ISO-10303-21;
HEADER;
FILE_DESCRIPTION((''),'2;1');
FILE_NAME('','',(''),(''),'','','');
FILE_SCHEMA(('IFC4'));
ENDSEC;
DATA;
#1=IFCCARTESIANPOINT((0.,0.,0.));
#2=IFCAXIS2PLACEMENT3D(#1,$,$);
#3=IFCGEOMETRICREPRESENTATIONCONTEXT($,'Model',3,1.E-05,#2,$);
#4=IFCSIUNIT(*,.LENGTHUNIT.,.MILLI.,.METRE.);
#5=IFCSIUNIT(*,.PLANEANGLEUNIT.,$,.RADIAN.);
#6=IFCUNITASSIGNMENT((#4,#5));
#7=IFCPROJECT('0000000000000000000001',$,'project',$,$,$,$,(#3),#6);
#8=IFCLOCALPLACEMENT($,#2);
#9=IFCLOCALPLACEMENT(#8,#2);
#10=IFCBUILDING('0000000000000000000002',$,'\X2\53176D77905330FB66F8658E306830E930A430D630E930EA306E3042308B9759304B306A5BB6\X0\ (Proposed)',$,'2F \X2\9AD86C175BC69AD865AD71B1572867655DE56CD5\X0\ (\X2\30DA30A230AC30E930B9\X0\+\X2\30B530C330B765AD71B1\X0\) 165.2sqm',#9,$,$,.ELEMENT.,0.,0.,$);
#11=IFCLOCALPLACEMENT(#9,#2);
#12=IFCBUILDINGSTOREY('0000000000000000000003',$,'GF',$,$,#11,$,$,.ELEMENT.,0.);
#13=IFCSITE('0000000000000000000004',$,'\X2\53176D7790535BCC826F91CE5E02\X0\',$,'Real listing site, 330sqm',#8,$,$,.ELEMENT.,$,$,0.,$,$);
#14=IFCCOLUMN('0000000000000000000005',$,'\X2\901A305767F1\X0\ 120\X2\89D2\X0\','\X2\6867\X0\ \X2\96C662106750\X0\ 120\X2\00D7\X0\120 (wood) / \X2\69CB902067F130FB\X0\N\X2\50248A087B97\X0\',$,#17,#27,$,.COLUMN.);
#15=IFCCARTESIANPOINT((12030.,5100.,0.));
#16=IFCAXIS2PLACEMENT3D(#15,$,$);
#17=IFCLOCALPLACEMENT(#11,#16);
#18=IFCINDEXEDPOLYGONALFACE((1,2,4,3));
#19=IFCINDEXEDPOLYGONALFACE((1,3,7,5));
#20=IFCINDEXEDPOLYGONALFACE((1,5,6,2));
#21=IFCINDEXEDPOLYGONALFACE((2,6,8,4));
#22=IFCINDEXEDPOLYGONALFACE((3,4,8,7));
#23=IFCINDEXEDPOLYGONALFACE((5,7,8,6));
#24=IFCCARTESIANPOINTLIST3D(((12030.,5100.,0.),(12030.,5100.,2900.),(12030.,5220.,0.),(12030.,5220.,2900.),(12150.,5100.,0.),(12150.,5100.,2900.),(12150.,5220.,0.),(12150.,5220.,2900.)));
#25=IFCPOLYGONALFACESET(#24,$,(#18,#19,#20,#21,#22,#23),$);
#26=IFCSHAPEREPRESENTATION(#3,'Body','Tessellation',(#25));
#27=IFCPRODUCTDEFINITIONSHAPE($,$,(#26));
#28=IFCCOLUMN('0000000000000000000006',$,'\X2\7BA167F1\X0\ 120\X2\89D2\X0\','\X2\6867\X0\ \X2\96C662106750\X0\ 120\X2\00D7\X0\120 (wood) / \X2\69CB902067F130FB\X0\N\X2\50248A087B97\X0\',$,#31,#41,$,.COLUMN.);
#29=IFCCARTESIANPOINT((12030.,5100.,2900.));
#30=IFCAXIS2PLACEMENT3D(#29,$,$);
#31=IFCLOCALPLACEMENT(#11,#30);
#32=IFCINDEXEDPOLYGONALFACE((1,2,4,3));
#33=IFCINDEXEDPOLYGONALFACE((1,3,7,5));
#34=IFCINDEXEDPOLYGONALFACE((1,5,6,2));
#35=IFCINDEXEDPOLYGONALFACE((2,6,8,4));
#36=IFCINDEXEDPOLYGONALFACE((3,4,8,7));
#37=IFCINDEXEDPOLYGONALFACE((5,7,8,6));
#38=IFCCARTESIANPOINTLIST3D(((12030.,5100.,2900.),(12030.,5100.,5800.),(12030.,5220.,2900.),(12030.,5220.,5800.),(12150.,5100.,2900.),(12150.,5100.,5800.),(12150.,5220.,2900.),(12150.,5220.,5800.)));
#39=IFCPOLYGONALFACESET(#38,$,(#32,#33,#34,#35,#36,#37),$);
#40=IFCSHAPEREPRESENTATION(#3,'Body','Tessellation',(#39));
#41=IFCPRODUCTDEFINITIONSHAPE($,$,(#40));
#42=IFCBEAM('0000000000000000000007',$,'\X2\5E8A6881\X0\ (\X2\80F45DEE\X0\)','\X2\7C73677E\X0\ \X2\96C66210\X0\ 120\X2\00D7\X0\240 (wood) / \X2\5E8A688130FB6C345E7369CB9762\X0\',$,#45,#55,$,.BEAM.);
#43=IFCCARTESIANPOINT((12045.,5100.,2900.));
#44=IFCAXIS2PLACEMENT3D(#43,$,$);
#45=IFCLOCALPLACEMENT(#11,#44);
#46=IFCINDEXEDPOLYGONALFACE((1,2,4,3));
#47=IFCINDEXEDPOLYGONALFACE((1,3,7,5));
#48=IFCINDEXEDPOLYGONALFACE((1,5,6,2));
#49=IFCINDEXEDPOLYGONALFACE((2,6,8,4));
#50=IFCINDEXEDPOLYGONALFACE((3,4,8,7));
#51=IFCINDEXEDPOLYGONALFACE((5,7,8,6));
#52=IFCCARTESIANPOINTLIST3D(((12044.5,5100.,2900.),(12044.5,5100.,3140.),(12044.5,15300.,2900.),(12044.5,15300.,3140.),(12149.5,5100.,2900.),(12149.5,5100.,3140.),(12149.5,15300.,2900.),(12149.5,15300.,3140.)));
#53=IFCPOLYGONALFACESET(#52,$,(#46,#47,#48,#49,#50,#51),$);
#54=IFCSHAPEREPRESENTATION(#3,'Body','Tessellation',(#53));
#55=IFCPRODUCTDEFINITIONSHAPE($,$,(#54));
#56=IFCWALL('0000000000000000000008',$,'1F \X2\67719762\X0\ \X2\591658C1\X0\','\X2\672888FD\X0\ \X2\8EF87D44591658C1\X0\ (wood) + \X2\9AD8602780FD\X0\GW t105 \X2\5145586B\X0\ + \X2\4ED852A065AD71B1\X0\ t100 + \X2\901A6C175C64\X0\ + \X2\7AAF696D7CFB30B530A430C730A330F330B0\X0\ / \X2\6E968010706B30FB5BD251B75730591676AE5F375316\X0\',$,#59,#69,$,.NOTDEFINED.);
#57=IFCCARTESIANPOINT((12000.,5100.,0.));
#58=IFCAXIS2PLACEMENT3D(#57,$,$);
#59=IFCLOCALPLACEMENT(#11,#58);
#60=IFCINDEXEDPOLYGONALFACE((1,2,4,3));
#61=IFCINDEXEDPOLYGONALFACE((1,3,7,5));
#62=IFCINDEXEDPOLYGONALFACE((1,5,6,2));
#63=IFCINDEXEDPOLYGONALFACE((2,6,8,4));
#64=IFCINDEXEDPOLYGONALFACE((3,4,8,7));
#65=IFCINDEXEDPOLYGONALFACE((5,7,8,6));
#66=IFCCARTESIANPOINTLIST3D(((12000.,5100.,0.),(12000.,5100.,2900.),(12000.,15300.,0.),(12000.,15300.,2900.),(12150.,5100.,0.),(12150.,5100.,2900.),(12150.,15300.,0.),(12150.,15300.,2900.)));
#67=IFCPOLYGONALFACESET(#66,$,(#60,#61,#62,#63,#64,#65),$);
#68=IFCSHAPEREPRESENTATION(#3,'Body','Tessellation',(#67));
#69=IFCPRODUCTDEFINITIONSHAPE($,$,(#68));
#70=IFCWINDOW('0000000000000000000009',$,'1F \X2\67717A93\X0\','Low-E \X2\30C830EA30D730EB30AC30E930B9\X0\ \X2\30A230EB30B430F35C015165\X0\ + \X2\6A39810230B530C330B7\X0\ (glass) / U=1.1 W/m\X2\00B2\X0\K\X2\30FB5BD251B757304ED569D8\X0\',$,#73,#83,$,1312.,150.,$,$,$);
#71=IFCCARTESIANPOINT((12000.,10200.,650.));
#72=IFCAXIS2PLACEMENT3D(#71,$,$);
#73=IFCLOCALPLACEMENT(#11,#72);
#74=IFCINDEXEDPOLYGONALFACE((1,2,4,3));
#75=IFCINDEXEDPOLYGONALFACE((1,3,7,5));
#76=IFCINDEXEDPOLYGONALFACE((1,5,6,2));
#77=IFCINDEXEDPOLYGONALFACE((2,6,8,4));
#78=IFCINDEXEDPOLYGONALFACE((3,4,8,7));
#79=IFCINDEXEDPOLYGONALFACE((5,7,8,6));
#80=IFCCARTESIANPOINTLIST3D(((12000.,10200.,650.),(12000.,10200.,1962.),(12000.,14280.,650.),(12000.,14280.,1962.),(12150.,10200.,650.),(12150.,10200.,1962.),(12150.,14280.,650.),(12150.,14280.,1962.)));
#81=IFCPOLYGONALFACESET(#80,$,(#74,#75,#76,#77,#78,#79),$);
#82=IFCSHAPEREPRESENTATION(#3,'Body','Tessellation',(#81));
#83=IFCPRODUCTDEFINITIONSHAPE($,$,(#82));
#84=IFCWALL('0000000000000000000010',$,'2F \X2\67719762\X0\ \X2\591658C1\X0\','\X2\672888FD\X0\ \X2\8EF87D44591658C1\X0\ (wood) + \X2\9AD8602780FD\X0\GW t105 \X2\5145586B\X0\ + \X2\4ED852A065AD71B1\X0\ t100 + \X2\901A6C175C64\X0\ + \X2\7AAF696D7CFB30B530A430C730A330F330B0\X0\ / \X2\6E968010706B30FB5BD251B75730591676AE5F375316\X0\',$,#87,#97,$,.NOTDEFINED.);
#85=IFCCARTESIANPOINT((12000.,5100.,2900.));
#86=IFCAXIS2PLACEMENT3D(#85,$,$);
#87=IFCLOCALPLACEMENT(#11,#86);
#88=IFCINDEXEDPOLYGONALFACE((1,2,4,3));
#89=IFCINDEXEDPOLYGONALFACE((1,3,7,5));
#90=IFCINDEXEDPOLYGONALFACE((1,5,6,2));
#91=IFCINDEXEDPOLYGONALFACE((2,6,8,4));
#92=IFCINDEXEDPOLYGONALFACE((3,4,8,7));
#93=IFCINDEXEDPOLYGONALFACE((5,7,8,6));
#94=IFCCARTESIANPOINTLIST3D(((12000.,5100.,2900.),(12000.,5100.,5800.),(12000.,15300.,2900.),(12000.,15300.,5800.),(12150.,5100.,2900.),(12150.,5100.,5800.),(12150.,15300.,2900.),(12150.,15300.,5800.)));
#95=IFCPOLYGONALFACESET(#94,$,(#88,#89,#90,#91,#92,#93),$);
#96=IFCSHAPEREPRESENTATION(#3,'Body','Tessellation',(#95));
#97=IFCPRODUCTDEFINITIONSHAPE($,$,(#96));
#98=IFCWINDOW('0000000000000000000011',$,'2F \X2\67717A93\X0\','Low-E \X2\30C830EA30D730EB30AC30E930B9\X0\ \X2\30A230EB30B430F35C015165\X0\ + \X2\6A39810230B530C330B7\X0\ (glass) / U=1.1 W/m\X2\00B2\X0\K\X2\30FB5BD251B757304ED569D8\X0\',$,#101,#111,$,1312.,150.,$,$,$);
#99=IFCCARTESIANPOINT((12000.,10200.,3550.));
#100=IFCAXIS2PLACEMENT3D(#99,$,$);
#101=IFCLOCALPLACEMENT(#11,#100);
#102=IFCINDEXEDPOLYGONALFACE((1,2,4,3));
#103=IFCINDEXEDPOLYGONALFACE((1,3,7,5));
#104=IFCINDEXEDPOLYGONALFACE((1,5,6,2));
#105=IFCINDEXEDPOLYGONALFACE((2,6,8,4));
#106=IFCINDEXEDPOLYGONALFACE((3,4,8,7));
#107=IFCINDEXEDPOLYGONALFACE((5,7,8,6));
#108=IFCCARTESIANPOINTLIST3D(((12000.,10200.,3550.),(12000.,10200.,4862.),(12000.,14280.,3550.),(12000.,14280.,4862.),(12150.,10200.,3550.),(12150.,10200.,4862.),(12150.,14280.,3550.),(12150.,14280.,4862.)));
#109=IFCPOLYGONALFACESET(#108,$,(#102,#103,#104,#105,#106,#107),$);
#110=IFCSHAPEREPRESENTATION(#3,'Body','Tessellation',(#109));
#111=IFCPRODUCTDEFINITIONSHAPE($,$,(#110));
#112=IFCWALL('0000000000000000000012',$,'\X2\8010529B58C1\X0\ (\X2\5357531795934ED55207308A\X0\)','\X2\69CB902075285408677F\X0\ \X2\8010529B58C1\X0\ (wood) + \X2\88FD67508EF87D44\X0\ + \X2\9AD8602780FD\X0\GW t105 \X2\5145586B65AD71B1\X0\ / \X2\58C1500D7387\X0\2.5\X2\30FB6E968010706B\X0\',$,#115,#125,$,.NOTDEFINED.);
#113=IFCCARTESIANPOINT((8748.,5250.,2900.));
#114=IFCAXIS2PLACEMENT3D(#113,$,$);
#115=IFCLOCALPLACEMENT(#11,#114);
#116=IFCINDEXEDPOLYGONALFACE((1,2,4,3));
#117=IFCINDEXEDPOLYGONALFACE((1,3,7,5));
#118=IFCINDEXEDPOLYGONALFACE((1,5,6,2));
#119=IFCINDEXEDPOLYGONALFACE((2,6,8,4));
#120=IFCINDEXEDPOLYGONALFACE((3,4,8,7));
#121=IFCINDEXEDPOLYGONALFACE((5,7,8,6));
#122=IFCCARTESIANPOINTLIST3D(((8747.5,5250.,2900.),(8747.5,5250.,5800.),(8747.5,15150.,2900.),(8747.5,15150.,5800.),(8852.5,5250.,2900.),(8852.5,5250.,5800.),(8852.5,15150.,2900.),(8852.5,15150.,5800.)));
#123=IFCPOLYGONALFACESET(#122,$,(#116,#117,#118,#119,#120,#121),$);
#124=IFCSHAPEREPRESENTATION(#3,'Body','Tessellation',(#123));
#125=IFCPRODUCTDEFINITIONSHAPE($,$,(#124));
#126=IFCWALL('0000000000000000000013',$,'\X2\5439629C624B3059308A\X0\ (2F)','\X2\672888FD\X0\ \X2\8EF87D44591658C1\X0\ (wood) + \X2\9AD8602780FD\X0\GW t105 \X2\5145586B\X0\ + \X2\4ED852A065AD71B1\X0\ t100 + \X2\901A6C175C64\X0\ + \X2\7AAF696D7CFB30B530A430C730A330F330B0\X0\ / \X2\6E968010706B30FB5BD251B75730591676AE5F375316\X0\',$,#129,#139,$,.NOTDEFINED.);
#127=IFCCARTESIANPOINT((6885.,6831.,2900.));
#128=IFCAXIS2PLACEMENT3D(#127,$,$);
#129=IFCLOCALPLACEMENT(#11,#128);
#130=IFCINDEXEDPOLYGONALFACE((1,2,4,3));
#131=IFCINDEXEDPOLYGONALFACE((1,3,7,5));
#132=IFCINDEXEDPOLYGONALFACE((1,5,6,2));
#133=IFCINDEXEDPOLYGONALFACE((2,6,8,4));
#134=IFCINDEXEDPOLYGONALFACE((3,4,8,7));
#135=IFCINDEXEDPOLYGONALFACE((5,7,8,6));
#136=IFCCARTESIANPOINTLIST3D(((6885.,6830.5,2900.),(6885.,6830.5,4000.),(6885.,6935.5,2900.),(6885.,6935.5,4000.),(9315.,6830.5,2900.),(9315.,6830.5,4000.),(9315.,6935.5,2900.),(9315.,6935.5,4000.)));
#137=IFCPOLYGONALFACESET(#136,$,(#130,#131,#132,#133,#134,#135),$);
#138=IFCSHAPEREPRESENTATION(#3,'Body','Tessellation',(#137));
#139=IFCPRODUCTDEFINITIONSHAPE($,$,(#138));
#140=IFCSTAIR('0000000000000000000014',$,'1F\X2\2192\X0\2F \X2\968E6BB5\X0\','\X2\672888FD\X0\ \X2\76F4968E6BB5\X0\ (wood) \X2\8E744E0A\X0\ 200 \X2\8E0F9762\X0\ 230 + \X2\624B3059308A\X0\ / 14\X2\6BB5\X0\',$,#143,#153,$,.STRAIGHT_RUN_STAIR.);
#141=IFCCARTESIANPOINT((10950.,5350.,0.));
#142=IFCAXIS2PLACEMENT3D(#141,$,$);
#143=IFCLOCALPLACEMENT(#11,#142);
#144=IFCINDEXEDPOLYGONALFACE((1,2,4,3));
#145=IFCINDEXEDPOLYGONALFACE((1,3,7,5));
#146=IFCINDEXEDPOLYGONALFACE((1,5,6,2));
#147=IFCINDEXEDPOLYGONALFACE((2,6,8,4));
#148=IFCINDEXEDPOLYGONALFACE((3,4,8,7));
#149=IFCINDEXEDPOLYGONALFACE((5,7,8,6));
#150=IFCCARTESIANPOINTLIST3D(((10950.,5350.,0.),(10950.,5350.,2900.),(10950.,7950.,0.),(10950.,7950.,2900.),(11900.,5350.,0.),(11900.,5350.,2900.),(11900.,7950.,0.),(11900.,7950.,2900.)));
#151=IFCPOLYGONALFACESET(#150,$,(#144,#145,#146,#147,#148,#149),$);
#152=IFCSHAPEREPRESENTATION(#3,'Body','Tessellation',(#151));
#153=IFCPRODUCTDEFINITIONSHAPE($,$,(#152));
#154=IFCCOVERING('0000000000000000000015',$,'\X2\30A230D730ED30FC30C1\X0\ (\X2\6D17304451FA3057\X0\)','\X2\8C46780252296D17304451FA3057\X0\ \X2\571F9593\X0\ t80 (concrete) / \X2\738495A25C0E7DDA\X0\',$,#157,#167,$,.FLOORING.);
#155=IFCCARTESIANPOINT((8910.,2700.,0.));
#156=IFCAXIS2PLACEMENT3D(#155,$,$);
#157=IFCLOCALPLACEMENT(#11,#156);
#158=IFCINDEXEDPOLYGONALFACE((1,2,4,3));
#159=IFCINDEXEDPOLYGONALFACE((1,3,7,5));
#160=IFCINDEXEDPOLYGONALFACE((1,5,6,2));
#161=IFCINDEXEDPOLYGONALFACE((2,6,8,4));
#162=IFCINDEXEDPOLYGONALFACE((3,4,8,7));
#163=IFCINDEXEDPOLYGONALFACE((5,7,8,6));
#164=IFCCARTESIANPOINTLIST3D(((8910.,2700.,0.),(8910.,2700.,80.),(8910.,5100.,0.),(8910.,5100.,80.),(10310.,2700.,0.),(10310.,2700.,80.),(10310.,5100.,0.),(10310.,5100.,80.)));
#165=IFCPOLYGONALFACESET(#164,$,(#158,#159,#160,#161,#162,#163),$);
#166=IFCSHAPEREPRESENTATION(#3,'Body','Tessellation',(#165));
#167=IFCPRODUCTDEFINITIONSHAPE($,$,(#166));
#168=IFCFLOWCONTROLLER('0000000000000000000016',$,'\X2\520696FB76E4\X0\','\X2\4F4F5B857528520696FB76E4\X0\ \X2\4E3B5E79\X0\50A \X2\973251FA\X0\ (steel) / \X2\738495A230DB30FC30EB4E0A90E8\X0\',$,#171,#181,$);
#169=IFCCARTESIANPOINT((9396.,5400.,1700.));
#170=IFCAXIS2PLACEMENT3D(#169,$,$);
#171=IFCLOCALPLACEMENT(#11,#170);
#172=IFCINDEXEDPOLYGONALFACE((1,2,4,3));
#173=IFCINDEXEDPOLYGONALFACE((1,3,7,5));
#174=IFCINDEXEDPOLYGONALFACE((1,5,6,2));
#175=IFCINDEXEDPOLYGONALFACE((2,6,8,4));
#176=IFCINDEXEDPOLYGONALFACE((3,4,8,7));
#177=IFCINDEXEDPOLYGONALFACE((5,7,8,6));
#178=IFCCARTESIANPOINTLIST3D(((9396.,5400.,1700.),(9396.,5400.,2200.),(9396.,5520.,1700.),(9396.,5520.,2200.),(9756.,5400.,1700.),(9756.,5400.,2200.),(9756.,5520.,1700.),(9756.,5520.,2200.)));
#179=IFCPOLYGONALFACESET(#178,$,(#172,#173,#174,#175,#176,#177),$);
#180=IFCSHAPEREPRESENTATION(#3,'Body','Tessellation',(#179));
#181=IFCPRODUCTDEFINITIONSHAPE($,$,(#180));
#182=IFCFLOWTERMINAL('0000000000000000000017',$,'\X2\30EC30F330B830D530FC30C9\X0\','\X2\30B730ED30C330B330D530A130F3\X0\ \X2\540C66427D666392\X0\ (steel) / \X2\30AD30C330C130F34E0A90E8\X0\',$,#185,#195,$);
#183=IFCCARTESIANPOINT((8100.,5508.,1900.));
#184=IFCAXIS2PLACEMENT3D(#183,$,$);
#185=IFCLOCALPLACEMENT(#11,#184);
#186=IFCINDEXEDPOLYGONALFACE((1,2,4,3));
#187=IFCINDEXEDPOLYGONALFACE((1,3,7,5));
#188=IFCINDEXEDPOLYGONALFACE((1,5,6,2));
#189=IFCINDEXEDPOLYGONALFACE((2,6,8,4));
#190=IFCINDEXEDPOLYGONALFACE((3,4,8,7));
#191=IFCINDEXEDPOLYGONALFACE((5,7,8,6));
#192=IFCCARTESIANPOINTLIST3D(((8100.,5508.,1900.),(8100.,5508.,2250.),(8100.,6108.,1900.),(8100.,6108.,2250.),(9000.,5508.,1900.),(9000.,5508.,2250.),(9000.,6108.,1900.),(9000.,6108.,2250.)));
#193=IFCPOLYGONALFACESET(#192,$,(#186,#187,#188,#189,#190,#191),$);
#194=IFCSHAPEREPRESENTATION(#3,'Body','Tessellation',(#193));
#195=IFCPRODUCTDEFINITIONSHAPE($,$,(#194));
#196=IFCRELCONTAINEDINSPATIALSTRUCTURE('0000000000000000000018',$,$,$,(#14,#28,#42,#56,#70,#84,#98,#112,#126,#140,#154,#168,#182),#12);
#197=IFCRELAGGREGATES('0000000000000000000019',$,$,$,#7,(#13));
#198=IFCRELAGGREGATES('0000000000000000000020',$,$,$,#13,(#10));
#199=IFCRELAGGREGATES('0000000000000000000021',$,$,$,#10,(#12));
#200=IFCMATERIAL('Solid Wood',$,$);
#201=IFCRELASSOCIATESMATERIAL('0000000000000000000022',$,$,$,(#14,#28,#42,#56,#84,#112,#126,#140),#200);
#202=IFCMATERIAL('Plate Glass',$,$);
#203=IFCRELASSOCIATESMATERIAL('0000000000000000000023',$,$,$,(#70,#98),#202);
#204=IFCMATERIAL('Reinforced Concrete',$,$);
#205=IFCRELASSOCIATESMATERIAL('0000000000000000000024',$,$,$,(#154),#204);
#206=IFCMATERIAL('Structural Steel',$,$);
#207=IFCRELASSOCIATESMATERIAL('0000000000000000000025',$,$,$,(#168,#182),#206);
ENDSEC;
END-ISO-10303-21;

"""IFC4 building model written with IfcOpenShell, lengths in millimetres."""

from ifc_helpers import new_model, si_unit, frame, frame_2d, origin, place, context, project, spatial, rectangle, extrude, material, element, fill, save


model = new_model("IFC4")

# Units and contexts
model_context = context("Model", 3, precision=1e-05, world=origin())
ifc_project = project(units=[si_unit("LENGTHUNIT", "METRE", prefix="MILLI"), si_unit("PLANEANGLEUNIT", "RADIAN")], contexts=[model_context])

# Site, building, storey
site_placement = place(None, origin())
site = spatial("IfcSite", under=ifc_project, at=site_placement, Name="北海道富良野市", ObjectType="Real listing site, 330sqm", CompositionType="ELEMENT", RefElevation=0.0)
building_placement = place(site_placement, origin())
building = spatial("IfcBuilding", under=site, at=building_placement, Name="北海道・書斎とライブラリのある静かな家 (Proposed)", ObjectType="2F 高気密高断熱在来工法 (ペアガラス+サッシ断熱) 165.2sqm", CompositionType="ELEMENT", ElevationOfRefHeight=0.0, ElevationOfTerrain=0.0)
storey_placement = place(building_placement, origin())
storey = spatial("IfcBuildingStorey", under=building, at=storey_placement, Name="GF", CompositionType="ELEMENT", Elevation=0.0)

# Columns
ifc_material_1 = material(Name="Solid Wood")
column_1_placement = place(storey_placement, frame((12030.0, 5100.0, 0.0)))
element("IfcColumn", 1, at=column_1_placement, inside=storey, material=ifc_material_1, Name="通し柱 120角", Description="桧 集成材 120×120 (wood) / 構造柱・N値計算", PredefinedType="COLUMN", context=model_context, shape_type="SweptSolid", body=[
    extrude(rectangle(XDim=120.0, YDim=120.0, at=frame_2d((60.0, 60.0))), frame((12030.0, 5100.0, 0.0)), (0.0, 0.0, 1.0), 2900.0),
])
column_2_placement = place(storey_placement, frame((12030.0, 5100.0, 2900.0)))
element("IfcColumn", 2, at=column_2_placement, inside=storey, material=ifc_material_1, Name="管柱 120角", Description="桧 集成材 120×120 (wood) / 構造柱・N値計算", PredefinedType="COLUMN", context=model_context, shape_type="SweptSolid", body=[
    extrude(rectangle(XDim=120.0, YDim=120.0, at=frame_2d((60.0, 60.0))), frame((12030.0, 5100.0, 2900.0)), (0.0, 0.0, 1.0), 2900.0),
])

# Beam
beam_1_placement = place(storey_placement, frame((12045.0, 5100.0, 2900.0)))
element("IfcBeam", 3, at=beam_1_placement, inside=storey, material=ifc_material_1, Name="床梁 (胴差)", Description="米松 集成 120×240 (wood) / 床梁・水平構面", PredefinedType="BEAM", context=model_context, shape_type="SweptSolid", body=[
    extrude(rectangle(XDim=105.0, YDim=10200.0, at=frame_2d((52.0, 5100.0))), frame((12045.0, 5100.0, 2900.0)), (0.0, 0.0, 1.0), 240.0),
])

# Wall, opening, window
wall_1_placement = place(storey_placement, frame((12000.0, 5100.0, 0.0)))
wall_1 = element("IfcWall", 4, at=wall_1_placement, inside=storey, material=ifc_material_1, Name="1F 東面 外壁", Description="木製 軸組外壁 (wood) + 高性能GW t105 充填 + 付加断熱 t100 + 通気層 + 窯業系サイディング / 準耐火・寒冷地外皮強化", PredefinedType="NOTDEFINED", context=model_context, shape_type="SweptSolid", body=[
    extrude(rectangle(XDim=150.0, YDim=10200.0, at=frame_2d((75.0, 5100.0))), frame((12000.0, 5100.0, 0.0)), (0.0, 0.0, 1.0), 2900.0),
])
opening_1_placement = place(storey_placement, frame((12000.0, 10200.0, 650.0)))
opening_1 = element("IfcOpeningElement", 5, at=opening_1_placement, cuts=wall_1, PredefinedType="NOTDEFINED", context=model_context, shape_type="SweptSolid", body=[
    extrude(rectangle(XDim=150.0, YDim=4080.0, at=frame_2d((75.0, 2040.0))), frame((12000.0, 10200.0, 650.0)), (0.0, 0.0, 1.0), 1312.0),
])
ifc_material_2 = material(Name="Plate Glass")
window_1_placement = place(storey_placement, frame((12000.0, 10200.0, 650.0)))
window_1 = element("IfcWindow", 6, at=window_1_placement, inside=storey, material=ifc_material_2, Name="1F 東窓", Description="Low-E トリプルガラス アルゴン封入 + 樹脂サッシ (glass) / U=1.1 W/m²K・寒冷地仕様", OverallHeight=1312.0, OverallWidth=150.0, context=model_context, shape_type="SweptSolid", body=[
    extrude(rectangle(XDim=150.0, YDim=4080.0, at=frame_2d((75.0, 2040.0))), frame((12000.0, 10200.0, 650.0)), (0.0, 0.0, 1.0), 1312.0),
])
fill(opening_1, window_1)

# Wall, opening, window
wall_2_placement = place(storey_placement, frame((12000.0, 5100.0, 2900.0)))
wall_2 = element("IfcWall", 7, at=wall_2_placement, inside=storey, material=ifc_material_1, Name="2F 東面 外壁", Description="木製 軸組外壁 (wood) + 高性能GW t105 充填 + 付加断熱 t100 + 通気層 + 窯業系サイディング / 準耐火・寒冷地外皮強化", PredefinedType="NOTDEFINED", context=model_context, shape_type="SweptSolid", body=[
    extrude(rectangle(XDim=150.0, YDim=10200.0, at=frame_2d((75.0, 5100.0))), frame((12000.0, 5100.0, 2900.0)), (0.0, 0.0, 1.0), 2900.0),
])
opening_2_placement = place(storey_placement, frame((12000.0, 10200.0, 3550.0)))
opening_2 = element("IfcOpeningElement", 8, at=opening_2_placement, cuts=wall_2, PredefinedType="NOTDEFINED", context=model_context, shape_type="SweptSolid", body=[
    extrude(rectangle(XDim=150.0, YDim=4080.0, at=frame_2d((75.0, 2040.0))), frame((12000.0, 10200.0, 3550.0)), (0.0, 0.0, 1.0), 1312.0),
])
window_2_placement = place(storey_placement, frame((12000.0, 10200.0, 3550.0)))
window_2 = element("IfcWindow", 9, at=window_2_placement, inside=storey, material=ifc_material_2, Name="2F 東窓", Description="Low-E トリプルガラス アルゴン封入 + 樹脂サッシ (glass) / U=1.1 W/m²K・寒冷地仕様", OverallHeight=1312.0, OverallWidth=150.0, context=model_context, shape_type="SweptSolid", body=[
    extrude(rectangle(XDim=150.0, YDim=4080.0, at=frame_2d((75.0, 2040.0))), frame((12000.0, 10200.0, 3550.0)), (0.0, 0.0, 1.0), 1312.0),
])
fill(opening_2, window_2)

# Walls
wall_3_placement = place(storey_placement, frame((8748.0, 5250.0, 2900.0)))
element("IfcWall", 10, at=wall_3_placement, inside=storey, material=ifc_material_1, Name="耐力壁 (南北間仕切り)", Description="構造用合板 耐力壁 (wood) + 製材軸組 + 高性能GW t105 充填断熱 / 壁倍率2.5・準耐火", PredefinedType="NOTDEFINED", context=model_context, shape_type="SweptSolid", body=[
    extrude(rectangle(XDim=105.0, YDim=9900.0, at=frame_2d((52.0, 4950.0))), frame((8748.0, 5250.0, 2900.0)), (0.0, 0.0, 1.0), 2900.0),
])
wall_4_placement = place(storey_placement, frame((6885.0, 6831.0, 2900.0)))
element("IfcWall", 11, at=wall_4_placement, inside=storey, material=ifc_material_1, Name="吹抜手すり (2F)", Description="木製 軸組外壁 (wood) + 高性能GW t105 充填 + 付加断熱 t100 + 通気層 + 窯業系サイディング / 準耐火・寒冷地外皮強化", PredefinedType="NOTDEFINED", context=model_context, shape_type="SweptSolid", body=[
    extrude(rectangle(XDim=2430.0, YDim=105.0, at=frame_2d((1215.0, 52.0))), frame((6885.0, 6831.0, 2900.0)), (0.0, 0.0, 1.0), 1100.0),
])

# Stair
stair_placement = place(storey_placement, frame((10950.0, 5350.0, 0.0)))
element("IfcStair", 12, at=stair_placement, inside=storey, material=ifc_material_1, Name="1F→2F 階段", Description="木製 直階段 (wood) 蹴上 200 踏面 230 + 手すり / 14段", PredefinedType="STRAIGHT_RUN_STAIR", context=model_context, shape_type="SweptSolid", body=[
    extrude(rectangle(XDim=950.0, YDim=2600.0, at=frame_2d((475.0, 1300.0))), frame((10950.0, 5350.0, 0.0)), (0.0, 0.0, 1.0), 2900.0),
])

# Covering
ifc_material_3 = material(Name="Reinforced Concrete")
covering_placement = place(storey_placement, frame((8910.0, 2700.0, 0.0)))
element("IfcCovering", 13, at=covering_placement, inside=storey, material=ifc_material_3, Name="アプローチ (洗い出し)", Description="豆砂利洗い出し 土間 t80 (concrete) / 玄関導線", PredefinedType="FLOORING", context=model_context, shape_type="SweptSolid", body=[
    extrude(rectangle(XDim=1400.0, YDim=2400.0, at=frame_2d((700.0, 1200.0))), frame((8910.0, 2700.0, 0.0)), (0.0, 0.0, 1.0), 80.0),
])

# Flow controller
ifc_material_4 = material(Name="Structural Steel")
flow_controller_placement = place(storey_placement, frame((9396.0, 5400.0, 1700.0)))
element("IfcFlowController", 14, at=flow_controller_placement, inside=storey, material=ifc_material_4, Name="分電盤", Description="住宅用分電盤 主幹50A 露出 (steel) / 玄関ホール上部", context=model_context, shape_type="SweptSolid", body=[
    extrude(rectangle(XDim=360.0, YDim=120.0, at=frame_2d((180.0, 60.0))), frame((9396.0, 5400.0, 1700.0)), (0.0, 0.0, 1.0), 500.0),
])

# Flow terminal
flow_terminal_1_placement = place(storey_placement, frame((8100.0, 5508.0, 1900.0)))
element("IfcFlowTerminal", 15, at=flow_terminal_1_placement, inside=storey, material=ifc_material_4, Name="レンジフード", Description="シロッコファン 同時給排 (steel) / キッチン上部", context=model_context, shape_type="SweptSolid", body=[
    extrude(rectangle(XDim=900.0, YDim=600.0, at=frame_2d((450.0, 300.0))), frame((8100.0, 5508.0, 1900.0)), (0.0, 0.0, 1.0), 350.0),
])

save(model, "model.ifc")
